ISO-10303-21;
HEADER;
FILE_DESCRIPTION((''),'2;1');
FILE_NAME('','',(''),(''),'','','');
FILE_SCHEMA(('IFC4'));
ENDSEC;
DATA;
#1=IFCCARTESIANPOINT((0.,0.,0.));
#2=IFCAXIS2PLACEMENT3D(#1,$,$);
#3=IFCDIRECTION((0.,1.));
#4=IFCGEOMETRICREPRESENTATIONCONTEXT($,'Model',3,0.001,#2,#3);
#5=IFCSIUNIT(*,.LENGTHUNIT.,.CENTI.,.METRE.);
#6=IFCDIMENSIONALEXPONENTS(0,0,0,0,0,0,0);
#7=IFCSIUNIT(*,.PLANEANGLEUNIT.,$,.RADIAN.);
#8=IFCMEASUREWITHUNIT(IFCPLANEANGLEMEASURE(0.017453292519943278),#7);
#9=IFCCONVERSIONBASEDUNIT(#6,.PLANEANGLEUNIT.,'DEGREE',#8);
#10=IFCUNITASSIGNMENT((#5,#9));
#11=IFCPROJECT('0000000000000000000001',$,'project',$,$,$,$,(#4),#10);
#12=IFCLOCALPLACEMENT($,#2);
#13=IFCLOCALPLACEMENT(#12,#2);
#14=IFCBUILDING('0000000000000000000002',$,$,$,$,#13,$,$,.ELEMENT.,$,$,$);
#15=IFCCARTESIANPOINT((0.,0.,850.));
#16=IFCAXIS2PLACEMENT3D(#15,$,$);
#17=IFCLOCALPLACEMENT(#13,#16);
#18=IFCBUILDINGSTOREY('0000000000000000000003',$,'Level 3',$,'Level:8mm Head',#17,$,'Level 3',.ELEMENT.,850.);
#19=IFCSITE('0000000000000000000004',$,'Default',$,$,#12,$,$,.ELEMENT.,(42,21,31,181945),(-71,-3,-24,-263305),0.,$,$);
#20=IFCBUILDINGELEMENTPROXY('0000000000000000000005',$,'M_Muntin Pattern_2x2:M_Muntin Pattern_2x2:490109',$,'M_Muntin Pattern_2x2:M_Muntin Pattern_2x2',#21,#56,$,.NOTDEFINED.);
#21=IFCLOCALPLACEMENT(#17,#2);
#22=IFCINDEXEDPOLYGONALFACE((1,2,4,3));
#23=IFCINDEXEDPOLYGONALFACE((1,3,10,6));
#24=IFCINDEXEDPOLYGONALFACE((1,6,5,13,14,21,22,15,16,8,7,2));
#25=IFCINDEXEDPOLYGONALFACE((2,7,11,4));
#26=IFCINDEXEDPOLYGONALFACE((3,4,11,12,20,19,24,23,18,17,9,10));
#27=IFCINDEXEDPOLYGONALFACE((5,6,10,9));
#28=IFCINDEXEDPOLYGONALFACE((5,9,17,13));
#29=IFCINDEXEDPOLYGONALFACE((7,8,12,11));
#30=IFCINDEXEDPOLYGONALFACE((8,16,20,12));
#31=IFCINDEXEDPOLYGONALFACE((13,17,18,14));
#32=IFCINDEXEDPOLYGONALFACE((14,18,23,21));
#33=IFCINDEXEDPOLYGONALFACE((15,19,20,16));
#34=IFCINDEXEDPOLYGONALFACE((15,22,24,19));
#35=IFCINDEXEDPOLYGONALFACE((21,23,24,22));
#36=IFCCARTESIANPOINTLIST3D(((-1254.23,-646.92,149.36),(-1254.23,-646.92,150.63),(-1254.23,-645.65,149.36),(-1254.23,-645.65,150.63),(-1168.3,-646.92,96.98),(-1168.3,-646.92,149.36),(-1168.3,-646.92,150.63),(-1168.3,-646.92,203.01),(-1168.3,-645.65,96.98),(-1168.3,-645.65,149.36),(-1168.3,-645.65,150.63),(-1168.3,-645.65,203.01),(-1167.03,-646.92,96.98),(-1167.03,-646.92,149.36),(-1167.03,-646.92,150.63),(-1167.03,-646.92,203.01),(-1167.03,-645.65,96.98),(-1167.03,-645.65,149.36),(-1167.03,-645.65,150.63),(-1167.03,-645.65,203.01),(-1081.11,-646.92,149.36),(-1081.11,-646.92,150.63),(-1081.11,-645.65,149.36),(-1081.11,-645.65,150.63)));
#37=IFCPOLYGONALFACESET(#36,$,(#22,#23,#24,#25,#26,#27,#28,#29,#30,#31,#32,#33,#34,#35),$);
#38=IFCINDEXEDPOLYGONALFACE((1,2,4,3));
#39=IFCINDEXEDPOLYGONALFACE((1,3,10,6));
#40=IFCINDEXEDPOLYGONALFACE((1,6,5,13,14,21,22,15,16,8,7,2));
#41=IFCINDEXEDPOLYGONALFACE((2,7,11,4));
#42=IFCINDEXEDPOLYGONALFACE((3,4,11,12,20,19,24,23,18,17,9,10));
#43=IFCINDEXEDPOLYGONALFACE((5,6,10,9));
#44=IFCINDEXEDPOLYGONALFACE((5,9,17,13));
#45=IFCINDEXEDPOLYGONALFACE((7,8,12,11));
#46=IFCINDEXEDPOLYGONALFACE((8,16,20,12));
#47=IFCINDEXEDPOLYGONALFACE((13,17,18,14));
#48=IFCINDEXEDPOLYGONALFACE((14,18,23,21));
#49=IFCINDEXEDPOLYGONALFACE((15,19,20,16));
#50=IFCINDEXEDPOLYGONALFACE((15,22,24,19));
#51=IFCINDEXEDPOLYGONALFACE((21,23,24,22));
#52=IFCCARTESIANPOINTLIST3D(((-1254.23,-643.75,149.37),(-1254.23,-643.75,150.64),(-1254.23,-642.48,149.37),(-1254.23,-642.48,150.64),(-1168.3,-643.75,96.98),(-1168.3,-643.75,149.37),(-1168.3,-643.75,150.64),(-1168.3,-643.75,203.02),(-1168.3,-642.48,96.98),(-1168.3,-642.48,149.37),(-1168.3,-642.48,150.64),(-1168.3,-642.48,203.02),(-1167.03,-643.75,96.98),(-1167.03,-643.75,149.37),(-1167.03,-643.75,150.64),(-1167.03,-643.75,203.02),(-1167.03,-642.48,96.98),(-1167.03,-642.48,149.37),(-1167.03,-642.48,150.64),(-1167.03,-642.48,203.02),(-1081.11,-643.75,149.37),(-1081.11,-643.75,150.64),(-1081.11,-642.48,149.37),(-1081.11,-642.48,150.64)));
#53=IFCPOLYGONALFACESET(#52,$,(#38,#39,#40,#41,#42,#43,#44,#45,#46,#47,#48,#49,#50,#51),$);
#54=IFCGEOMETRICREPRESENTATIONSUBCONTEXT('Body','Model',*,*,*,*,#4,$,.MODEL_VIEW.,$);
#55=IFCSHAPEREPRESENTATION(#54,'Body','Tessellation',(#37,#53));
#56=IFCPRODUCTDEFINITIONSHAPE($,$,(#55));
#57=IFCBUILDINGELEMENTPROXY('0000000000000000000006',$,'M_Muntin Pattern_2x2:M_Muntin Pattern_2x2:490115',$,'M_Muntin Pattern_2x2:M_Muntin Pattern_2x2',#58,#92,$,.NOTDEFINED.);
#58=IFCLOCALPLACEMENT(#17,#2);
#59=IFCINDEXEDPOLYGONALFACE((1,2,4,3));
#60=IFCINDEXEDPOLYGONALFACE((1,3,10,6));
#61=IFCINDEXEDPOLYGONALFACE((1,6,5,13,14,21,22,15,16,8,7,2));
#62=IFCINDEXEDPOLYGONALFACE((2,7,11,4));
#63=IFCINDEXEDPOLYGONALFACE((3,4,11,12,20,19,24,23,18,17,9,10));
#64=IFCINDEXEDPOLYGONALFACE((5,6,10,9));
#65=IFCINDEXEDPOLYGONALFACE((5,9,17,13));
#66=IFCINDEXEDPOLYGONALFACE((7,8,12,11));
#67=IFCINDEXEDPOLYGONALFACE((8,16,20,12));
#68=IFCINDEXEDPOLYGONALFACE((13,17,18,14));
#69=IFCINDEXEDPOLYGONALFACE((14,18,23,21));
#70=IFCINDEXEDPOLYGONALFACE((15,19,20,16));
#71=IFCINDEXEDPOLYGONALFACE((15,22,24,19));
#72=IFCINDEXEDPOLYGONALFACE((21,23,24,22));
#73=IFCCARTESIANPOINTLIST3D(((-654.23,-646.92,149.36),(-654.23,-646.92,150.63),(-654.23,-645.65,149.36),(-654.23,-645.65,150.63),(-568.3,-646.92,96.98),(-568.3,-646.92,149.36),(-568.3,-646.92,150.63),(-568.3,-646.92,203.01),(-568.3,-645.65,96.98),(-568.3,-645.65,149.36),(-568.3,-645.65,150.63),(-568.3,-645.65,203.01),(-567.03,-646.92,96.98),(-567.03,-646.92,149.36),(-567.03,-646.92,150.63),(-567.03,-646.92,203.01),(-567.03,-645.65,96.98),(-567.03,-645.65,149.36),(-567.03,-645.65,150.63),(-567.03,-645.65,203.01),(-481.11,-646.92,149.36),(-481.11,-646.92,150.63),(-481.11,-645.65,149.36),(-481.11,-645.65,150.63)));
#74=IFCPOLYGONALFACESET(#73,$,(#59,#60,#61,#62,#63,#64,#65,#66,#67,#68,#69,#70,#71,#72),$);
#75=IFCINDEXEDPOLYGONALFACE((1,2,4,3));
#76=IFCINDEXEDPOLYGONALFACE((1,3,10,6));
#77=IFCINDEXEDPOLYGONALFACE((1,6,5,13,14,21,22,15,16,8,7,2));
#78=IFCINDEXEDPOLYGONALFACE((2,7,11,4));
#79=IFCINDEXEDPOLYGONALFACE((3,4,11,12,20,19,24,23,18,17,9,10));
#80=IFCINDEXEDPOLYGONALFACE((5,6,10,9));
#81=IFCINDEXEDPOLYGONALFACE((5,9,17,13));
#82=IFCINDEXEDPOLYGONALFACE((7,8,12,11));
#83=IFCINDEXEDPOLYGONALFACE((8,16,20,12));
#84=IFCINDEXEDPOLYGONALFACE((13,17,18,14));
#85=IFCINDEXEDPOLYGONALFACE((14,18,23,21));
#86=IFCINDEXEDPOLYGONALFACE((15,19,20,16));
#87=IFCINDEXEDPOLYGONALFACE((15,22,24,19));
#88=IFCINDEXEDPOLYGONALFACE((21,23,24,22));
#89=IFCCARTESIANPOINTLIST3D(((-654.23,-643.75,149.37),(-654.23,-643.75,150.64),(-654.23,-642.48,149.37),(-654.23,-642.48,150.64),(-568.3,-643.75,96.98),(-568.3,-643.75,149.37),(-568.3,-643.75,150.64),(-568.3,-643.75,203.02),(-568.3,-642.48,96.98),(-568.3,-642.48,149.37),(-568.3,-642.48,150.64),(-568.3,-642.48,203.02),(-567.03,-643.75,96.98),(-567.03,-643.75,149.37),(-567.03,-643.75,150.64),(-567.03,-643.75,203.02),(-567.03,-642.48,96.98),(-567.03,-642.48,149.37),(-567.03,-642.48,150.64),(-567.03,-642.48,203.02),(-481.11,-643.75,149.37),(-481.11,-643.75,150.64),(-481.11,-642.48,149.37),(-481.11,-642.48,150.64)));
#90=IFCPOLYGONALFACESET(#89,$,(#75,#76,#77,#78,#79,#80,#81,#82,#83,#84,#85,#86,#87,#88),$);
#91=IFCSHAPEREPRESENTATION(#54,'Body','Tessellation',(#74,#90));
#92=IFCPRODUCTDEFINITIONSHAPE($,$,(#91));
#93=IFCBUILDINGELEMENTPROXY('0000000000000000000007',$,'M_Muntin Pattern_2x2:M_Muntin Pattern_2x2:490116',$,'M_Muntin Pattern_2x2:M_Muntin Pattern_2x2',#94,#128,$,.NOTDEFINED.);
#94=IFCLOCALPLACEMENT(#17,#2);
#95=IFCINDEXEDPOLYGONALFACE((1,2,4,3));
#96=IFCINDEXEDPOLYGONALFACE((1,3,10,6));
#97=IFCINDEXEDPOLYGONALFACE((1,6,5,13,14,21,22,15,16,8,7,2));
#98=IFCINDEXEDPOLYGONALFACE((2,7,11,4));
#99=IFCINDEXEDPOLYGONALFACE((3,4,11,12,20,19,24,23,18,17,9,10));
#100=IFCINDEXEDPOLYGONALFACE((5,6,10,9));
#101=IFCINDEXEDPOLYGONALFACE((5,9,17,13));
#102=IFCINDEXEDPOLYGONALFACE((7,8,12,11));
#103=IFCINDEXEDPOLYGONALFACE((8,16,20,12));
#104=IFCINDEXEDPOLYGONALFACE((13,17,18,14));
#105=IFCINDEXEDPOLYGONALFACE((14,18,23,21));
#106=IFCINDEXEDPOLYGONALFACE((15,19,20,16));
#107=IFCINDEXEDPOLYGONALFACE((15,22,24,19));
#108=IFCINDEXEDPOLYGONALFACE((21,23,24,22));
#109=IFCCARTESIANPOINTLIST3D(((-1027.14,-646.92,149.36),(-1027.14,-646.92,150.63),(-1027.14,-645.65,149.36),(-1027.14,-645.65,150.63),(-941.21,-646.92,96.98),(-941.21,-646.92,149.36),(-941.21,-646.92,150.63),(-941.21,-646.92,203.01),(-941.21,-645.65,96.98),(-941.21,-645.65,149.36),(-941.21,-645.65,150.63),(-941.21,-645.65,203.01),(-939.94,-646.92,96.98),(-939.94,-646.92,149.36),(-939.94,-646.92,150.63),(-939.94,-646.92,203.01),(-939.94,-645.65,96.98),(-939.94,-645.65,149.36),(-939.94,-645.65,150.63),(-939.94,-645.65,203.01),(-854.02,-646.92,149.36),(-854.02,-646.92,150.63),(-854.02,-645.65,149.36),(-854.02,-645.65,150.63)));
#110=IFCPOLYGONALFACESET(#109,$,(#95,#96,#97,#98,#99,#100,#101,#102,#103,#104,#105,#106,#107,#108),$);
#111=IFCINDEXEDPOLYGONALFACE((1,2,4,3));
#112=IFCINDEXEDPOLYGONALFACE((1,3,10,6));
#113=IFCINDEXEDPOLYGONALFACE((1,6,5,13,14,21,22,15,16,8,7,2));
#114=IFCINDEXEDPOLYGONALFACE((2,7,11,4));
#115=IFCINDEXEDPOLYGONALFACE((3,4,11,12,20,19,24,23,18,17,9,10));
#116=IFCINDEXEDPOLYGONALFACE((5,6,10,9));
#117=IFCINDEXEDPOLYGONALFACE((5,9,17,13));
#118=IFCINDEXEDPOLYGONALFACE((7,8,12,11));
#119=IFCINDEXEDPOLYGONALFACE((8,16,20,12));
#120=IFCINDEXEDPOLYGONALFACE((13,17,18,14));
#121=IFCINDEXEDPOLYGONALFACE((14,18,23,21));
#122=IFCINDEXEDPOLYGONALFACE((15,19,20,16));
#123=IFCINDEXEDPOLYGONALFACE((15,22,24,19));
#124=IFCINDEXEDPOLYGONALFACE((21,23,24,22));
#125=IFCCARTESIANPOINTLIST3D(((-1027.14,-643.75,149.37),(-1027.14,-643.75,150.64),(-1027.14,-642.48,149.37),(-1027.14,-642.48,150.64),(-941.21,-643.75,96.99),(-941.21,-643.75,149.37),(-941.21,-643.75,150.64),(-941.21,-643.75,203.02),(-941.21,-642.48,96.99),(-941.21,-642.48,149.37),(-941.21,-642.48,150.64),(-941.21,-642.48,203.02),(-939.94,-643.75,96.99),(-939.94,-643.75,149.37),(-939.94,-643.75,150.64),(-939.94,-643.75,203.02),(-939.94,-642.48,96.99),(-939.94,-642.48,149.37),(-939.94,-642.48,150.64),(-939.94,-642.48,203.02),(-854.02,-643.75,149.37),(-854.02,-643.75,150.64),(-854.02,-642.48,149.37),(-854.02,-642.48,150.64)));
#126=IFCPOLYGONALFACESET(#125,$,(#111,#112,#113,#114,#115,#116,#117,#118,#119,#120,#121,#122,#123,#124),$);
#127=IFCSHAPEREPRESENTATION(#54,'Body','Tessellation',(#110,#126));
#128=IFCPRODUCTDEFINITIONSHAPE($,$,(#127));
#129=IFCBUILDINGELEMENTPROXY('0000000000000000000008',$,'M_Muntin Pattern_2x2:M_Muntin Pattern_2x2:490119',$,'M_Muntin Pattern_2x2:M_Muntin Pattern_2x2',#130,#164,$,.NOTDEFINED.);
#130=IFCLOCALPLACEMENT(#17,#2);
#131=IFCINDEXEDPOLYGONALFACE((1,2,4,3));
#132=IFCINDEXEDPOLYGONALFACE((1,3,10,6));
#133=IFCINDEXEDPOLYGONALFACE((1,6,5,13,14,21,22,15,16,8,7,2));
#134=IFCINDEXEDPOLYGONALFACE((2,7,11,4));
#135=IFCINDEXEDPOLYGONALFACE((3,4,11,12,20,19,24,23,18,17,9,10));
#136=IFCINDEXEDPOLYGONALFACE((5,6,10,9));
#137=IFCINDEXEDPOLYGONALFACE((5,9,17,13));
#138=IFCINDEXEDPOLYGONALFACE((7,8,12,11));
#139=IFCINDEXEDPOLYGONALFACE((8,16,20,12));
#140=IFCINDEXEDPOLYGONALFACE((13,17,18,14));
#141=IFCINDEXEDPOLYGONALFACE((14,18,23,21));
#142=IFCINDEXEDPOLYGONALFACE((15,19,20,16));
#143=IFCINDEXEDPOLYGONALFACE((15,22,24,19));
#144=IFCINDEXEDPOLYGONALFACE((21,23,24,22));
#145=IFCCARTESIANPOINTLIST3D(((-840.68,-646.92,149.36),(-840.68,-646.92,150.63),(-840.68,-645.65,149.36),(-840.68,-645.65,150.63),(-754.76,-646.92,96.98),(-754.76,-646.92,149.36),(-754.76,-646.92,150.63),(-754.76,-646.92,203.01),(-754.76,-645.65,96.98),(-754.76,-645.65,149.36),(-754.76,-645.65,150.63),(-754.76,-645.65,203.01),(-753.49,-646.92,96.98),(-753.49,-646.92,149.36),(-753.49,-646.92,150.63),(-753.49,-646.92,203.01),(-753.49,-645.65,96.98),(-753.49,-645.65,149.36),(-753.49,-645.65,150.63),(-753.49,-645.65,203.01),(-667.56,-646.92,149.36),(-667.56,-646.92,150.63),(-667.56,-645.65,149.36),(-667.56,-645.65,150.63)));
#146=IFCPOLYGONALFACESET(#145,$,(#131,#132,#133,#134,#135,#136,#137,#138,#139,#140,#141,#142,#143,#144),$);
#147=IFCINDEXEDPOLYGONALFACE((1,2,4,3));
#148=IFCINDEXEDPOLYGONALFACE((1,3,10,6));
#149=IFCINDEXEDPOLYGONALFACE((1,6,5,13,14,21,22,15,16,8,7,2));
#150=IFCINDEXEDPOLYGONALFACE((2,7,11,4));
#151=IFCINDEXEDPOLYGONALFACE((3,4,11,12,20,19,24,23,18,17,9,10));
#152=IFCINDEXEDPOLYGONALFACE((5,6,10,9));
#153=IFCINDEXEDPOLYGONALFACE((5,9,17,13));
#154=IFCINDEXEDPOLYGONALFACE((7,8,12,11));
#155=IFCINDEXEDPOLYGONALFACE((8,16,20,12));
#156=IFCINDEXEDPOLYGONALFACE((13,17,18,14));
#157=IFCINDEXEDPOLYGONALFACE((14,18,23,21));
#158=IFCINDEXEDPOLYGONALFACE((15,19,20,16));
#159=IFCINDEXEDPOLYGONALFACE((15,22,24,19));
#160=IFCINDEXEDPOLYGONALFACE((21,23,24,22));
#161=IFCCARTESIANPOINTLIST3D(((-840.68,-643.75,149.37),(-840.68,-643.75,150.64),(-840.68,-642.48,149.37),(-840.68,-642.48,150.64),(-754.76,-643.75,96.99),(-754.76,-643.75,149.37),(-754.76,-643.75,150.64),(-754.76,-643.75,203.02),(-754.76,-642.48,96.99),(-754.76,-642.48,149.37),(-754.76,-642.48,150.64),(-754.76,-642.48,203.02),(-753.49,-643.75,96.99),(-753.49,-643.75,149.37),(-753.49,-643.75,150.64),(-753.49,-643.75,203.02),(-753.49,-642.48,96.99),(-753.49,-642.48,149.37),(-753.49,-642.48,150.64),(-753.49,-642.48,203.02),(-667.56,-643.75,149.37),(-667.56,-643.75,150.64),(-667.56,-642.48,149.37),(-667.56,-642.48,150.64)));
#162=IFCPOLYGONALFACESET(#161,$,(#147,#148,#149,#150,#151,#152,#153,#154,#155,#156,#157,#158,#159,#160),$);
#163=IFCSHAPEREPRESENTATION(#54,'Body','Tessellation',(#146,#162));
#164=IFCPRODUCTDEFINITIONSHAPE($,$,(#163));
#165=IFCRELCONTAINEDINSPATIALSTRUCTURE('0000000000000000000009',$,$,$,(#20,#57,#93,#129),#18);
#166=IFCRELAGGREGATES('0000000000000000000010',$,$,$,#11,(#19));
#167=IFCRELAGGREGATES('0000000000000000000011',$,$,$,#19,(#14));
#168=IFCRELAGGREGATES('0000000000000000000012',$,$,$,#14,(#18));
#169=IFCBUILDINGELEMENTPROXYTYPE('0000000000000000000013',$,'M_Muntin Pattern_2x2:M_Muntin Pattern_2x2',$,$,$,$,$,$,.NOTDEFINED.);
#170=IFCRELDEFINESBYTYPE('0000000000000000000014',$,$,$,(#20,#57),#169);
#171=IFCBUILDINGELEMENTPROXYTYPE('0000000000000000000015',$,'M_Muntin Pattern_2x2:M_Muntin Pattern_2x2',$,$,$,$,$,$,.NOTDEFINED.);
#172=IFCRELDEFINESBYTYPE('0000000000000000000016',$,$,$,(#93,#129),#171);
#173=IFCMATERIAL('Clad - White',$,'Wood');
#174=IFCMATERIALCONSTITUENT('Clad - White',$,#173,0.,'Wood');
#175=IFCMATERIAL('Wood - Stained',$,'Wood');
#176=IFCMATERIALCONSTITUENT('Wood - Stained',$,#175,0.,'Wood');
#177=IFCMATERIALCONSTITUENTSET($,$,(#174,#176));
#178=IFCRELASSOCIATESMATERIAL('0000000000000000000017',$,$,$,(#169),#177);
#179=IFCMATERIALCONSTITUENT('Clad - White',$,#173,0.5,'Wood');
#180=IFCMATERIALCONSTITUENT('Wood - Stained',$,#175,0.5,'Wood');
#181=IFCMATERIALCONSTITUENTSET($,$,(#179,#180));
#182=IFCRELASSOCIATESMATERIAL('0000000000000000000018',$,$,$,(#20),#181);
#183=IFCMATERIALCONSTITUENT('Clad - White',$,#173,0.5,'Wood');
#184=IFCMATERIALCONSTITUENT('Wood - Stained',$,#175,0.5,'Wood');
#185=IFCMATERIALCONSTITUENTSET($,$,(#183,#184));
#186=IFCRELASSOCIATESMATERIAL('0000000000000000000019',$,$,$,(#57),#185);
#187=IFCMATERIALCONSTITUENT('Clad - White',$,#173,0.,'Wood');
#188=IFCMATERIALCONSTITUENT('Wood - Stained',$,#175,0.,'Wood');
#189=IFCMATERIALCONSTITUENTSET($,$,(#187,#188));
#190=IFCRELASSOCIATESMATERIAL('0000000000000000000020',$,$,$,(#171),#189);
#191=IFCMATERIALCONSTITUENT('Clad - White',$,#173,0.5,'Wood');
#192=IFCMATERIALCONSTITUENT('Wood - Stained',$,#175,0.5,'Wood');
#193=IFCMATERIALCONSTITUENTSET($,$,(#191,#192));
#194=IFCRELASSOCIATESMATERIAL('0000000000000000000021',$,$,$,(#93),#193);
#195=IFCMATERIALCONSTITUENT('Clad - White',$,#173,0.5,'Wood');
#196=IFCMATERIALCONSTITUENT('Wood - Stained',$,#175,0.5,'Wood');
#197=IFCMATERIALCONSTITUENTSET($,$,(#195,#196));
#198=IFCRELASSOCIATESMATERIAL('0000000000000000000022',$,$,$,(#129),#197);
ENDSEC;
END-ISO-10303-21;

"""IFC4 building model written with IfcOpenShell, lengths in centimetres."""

from ifc_helpers import new_model, entity, si_unit, converted_unit, direction, frame, origin, place, context, subcontext, project, spatial, indexed_curve, outline, extrude, source, transform, mapped, material, constituent, constituent_set, type_object, type_shapes, element, save


model = new_model("IFC4")

# Units and contexts
model_context = context("Model", 3, precision=0.001, world=origin(), true_north=direction((0.0, 1.0)))
body_context = subcontext(model_context, "Body", "Model", "MODEL_VIEW")
ifc_project = project(units=[si_unit("LENGTHUNIT", "METRE", prefix="CENTI"), converted_unit("PLANEANGLEUNIT", "DEGREE", entity("IfcPlaneAngleMeasure", 0.017453292519943278), si_unit("PLANEANGLEUNIT", "RADIAN"), dimensions=[0, 0, 0, 0, 0, 0, 0])], contexts=[model_context])

# Site, building, storey
site_placement = place(None, origin())
site = spatial("IfcSite", under=ifc_project, at=site_placement, Name="Default", CompositionType="ELEMENT", RefLatitude=(42, 21, 31, 181945), RefLongitude=(-71, -3, -24, -263305), RefElevation=0.0)
building_placement = place(site_placement, origin())
building = spatial("IfcBuilding", under=site, at=building_placement, CompositionType="ELEMENT")
storey_placement = place(building_placement, frame((0.0, 0.0, 850.0)))
storey = spatial("IfcBuildingStorey", under=building, at=storey_placement, Name="Level 3", ObjectType="Level:8mm Head", LongName="Level 3", CompositionType="ELEMENT", Elevation=850.0)

# Building element proxies
ifc_material_1 = material(Name="Clad - White", Category="Wood")
ifc_constituent_1 = constituent(ifc_material_1, Name="Clad - White", Category="Wood", fraction=0.5)
ifc_material_2 = material(Name="Wood - Stained", Category="Wood")
ifc_constituent_2 = constituent(ifc_material_2, Name="Wood - Stained", Category="Wood", fraction=0.5)
ifc_constituent_set_1 = constituent_set(constituents=[ifc_constituent_1, ifc_constituent_2])
ifc_constituent_3 = constituent(ifc_material_1, Name="Clad - White", Category="Wood", fraction=0.0)
ifc_constituent_4 = constituent(ifc_material_2, Name="Wood - Stained", Category="Wood", fraction=0.0)
ifc_constituent_set_2 = constituent_set(constituents=[ifc_constituent_3, ifc_constituent_4])
building_element_proxy_type_1 = type_object("IfcBuildingElementProxyType", Name="M_Muntin Pattern_2x2:M_Muntin Pattern_2x2", PredefinedType="NOTDEFINED", material=ifc_constituent_set_2)
shared_shape_1 = source(origin(), body_context, "Body", "SweptSolid", [
    extrude(outline(indexed_curve([(0.64, -0.64), (53.01, -0.64), (53.01, 0.63), (0.64, 0.63), (0.64, 86.56), (-0.63, 86.56), (-0.63, 0.63), (-53.02, 0.63), (-53.02, -0.64), (-0.63, -0.64), (-0.63, -86.56), (0.64, -86.56), (0.64, -0.64)], self_intersect=False)), frame((0.0, 0.95, 53.01), z_axis=(0.0, 1.0, 0.0), x_axis=(0.0, 0.0, 1.0)), (0.0, 0.0, 1.0), 1.27),
    extrude(outline(indexed_curve([(0.64, -0.64), (53.02, -0.64), (53.02, 0.63), (0.64, 0.63), (0.64, 86.56), (-0.63, 86.56), (-0.63, 0.63), (-53.02, 0.63), (-53.02, -0.64), (-0.63, -0.64), (-0.63, -86.56), (0.64, -86.56), (0.64, -0.64)], self_intersect=False)), frame((0.0, -2.22, 53.02), z_axis=(0.0, 1.0, 0.0), x_axis=(0.0, 0.0, 1.0)), (0.0, 0.0, 1.0), 1.27),
])
type_shapes(building_element_proxy_type_1, [shared_shape_1])
proxy_1_placement = place(storey_placement, frame((-1167.67, -644.7, 96.98), z_axis=(0.0, 0.0, 1.0), x_axis=(-1.0, 0.0, 0.0)))
element("IfcBuildingElementProxy", 1, at=proxy_1_placement, inside=storey, type_object=building_element_proxy_type_1, material=ifc_constituent_set_1, Name="M_Muntin Pattern_2x2:M_Muntin Pattern_2x2:490109", ObjectType="M_Muntin Pattern_2x2:M_Muntin Pattern_2x2", PredefinedType="NOTDEFINED", context=body_context, shape_type="MappedRepresentation", body=[
    mapped(shared_shape_1, transform((0.0, 0.0, 0.0), scale=1.0)),
])
ifc_constituent_5 = constituent(ifc_material_1, Name="Clad - White", Category="Wood", fraction=0.5)
ifc_constituent_6 = constituent(ifc_material_2, Name="Wood - Stained", Category="Wood", fraction=0.5)
ifc_constituent_set_3 = constituent_set(constituents=[ifc_constituent_5, ifc_constituent_6])
proxy_2_placement = place(storey_placement, frame((-567.67, -644.7, 96.98), z_axis=(0.0, 0.0, 1.0), x_axis=(-1.0, 0.0, 0.0)))
element("IfcBuildingElementProxy", 2, at=proxy_2_placement, inside=storey, type_object=building_element_proxy_type_1, material=ifc_constituent_set_3, Name="M_Muntin Pattern_2x2:M_Muntin Pattern_2x2:490115", ObjectType="M_Muntin Pattern_2x2:M_Muntin Pattern_2x2", PredefinedType="NOTDEFINED", context=body_context, shape_type="MappedRepresentation", body=[
    mapped(shared_shape_1, transform((0.0, 0.0, 0.0), scale=1.0)),
])
ifc_constituent_7 = constituent(ifc_material_1, Name="Clad - White", Category="Wood", fraction=0.5)
ifc_constituent_8 = constituent(ifc_material_2, Name="Wood - Stained", Category="Wood", fraction=0.5)
ifc_constituent_set_4 = constituent_set(constituents=[ifc_constituent_7, ifc_constituent_8])
ifc_constituent_9 = constituent(ifc_material_1, Name="Clad - White", Category="Wood", fraction=0.0)
ifc_constituent_10 = constituent(ifc_material_2, Name="Wood - Stained", Category="Wood", fraction=0.0)
ifc_constituent_set_5 = constituent_set(constituents=[ifc_constituent_9, ifc_constituent_10])
building_element_proxy_type_2 = type_object("IfcBuildingElementProxyType", Name="M_Muntin Pattern_2x2:M_Muntin Pattern_2x2", PredefinedType="NOTDEFINED", material=ifc_constituent_set_5)
shared_shape_2 = source(origin(), body_context, "Body", "SweptSolid", [
    extrude(outline(indexed_curve([(0.64, -0.64), (53.01, -0.64), (53.01, 0.63), (0.64, 0.63), (0.64, 86.56), (-0.63, 86.56), (-0.63, 0.63), (-53.02, 0.63), (-53.02, -0.64), (-0.63, -0.64), (-0.63, -86.56), (0.64, -86.56), (0.64, -0.64)], self_intersect=False)), frame((0.0, -2.22, 53.01), z_axis=(0.0, 1.0, 0.0), x_axis=(0.0, 0.0, 1.0)), (0.0, 0.0, 1.0), 1.27),
    extrude(outline(indexed_curve([(0.64, -0.64), (53.02, -0.64), (53.02, 0.63), (0.64, 0.63), (0.64, 86.56), (-0.63, 86.56), (-0.63, 0.63), (-53.02, 0.63), (-53.02, -0.64), (-0.63, -0.64), (-0.63, -86.56), (0.64, -86.56), (0.64, -0.64)], self_intersect=False)), frame((0.0, 0.95, 53.02), z_axis=(0.0, 1.0, 0.0), x_axis=(0.0, 0.0, 1.0)), (0.0, 0.0, 1.0), 1.27),
])
type_shapes(building_element_proxy_type_2, [shared_shape_2])
proxy_3_placement = place(storey_placement, frame((-940.58, -644.7, 96.99)))
element("IfcBuildingElementProxy", 3, at=proxy_3_placement, inside=storey, type_object=building_element_proxy_type_2, material=ifc_constituent_set_4, Name="M_Muntin Pattern_2x2:M_Muntin Pattern_2x2:490116", ObjectType="M_Muntin Pattern_2x2:M_Muntin Pattern_2x2", PredefinedType="NOTDEFINED", context=body_context, shape_type="MappedRepresentation", body=[
    mapped(shared_shape_2, transform((0.0, 0.0, 0.0), scale=1.0)),
])
ifc_constituent_11 = constituent(ifc_material_1, Name="Clad - White", Category="Wood", fraction=0.5)
ifc_constituent_12 = constituent(ifc_material_2, Name="Wood - Stained", Category="Wood", fraction=0.5)
ifc_constituent_set_6 = constituent_set(constituents=[ifc_constituent_11, ifc_constituent_12])
proxy_4_placement = place(storey_placement, frame((-754.12, -644.7, 96.99)))
element("IfcBuildingElementProxy", 4, at=proxy_4_placement, inside=storey, type_object=building_element_proxy_type_2, material=ifc_constituent_set_6, Name="M_Muntin Pattern_2x2:M_Muntin Pattern_2x2:490119", ObjectType="M_Muntin Pattern_2x2:M_Muntin Pattern_2x2", PredefinedType="NOTDEFINED", context=body_context, shape_type="MappedRepresentation", body=[
    mapped(shared_shape_2, transform((0.0, 0.0, 0.0), scale=1.0)),
])

save(model, "model.ifc")
